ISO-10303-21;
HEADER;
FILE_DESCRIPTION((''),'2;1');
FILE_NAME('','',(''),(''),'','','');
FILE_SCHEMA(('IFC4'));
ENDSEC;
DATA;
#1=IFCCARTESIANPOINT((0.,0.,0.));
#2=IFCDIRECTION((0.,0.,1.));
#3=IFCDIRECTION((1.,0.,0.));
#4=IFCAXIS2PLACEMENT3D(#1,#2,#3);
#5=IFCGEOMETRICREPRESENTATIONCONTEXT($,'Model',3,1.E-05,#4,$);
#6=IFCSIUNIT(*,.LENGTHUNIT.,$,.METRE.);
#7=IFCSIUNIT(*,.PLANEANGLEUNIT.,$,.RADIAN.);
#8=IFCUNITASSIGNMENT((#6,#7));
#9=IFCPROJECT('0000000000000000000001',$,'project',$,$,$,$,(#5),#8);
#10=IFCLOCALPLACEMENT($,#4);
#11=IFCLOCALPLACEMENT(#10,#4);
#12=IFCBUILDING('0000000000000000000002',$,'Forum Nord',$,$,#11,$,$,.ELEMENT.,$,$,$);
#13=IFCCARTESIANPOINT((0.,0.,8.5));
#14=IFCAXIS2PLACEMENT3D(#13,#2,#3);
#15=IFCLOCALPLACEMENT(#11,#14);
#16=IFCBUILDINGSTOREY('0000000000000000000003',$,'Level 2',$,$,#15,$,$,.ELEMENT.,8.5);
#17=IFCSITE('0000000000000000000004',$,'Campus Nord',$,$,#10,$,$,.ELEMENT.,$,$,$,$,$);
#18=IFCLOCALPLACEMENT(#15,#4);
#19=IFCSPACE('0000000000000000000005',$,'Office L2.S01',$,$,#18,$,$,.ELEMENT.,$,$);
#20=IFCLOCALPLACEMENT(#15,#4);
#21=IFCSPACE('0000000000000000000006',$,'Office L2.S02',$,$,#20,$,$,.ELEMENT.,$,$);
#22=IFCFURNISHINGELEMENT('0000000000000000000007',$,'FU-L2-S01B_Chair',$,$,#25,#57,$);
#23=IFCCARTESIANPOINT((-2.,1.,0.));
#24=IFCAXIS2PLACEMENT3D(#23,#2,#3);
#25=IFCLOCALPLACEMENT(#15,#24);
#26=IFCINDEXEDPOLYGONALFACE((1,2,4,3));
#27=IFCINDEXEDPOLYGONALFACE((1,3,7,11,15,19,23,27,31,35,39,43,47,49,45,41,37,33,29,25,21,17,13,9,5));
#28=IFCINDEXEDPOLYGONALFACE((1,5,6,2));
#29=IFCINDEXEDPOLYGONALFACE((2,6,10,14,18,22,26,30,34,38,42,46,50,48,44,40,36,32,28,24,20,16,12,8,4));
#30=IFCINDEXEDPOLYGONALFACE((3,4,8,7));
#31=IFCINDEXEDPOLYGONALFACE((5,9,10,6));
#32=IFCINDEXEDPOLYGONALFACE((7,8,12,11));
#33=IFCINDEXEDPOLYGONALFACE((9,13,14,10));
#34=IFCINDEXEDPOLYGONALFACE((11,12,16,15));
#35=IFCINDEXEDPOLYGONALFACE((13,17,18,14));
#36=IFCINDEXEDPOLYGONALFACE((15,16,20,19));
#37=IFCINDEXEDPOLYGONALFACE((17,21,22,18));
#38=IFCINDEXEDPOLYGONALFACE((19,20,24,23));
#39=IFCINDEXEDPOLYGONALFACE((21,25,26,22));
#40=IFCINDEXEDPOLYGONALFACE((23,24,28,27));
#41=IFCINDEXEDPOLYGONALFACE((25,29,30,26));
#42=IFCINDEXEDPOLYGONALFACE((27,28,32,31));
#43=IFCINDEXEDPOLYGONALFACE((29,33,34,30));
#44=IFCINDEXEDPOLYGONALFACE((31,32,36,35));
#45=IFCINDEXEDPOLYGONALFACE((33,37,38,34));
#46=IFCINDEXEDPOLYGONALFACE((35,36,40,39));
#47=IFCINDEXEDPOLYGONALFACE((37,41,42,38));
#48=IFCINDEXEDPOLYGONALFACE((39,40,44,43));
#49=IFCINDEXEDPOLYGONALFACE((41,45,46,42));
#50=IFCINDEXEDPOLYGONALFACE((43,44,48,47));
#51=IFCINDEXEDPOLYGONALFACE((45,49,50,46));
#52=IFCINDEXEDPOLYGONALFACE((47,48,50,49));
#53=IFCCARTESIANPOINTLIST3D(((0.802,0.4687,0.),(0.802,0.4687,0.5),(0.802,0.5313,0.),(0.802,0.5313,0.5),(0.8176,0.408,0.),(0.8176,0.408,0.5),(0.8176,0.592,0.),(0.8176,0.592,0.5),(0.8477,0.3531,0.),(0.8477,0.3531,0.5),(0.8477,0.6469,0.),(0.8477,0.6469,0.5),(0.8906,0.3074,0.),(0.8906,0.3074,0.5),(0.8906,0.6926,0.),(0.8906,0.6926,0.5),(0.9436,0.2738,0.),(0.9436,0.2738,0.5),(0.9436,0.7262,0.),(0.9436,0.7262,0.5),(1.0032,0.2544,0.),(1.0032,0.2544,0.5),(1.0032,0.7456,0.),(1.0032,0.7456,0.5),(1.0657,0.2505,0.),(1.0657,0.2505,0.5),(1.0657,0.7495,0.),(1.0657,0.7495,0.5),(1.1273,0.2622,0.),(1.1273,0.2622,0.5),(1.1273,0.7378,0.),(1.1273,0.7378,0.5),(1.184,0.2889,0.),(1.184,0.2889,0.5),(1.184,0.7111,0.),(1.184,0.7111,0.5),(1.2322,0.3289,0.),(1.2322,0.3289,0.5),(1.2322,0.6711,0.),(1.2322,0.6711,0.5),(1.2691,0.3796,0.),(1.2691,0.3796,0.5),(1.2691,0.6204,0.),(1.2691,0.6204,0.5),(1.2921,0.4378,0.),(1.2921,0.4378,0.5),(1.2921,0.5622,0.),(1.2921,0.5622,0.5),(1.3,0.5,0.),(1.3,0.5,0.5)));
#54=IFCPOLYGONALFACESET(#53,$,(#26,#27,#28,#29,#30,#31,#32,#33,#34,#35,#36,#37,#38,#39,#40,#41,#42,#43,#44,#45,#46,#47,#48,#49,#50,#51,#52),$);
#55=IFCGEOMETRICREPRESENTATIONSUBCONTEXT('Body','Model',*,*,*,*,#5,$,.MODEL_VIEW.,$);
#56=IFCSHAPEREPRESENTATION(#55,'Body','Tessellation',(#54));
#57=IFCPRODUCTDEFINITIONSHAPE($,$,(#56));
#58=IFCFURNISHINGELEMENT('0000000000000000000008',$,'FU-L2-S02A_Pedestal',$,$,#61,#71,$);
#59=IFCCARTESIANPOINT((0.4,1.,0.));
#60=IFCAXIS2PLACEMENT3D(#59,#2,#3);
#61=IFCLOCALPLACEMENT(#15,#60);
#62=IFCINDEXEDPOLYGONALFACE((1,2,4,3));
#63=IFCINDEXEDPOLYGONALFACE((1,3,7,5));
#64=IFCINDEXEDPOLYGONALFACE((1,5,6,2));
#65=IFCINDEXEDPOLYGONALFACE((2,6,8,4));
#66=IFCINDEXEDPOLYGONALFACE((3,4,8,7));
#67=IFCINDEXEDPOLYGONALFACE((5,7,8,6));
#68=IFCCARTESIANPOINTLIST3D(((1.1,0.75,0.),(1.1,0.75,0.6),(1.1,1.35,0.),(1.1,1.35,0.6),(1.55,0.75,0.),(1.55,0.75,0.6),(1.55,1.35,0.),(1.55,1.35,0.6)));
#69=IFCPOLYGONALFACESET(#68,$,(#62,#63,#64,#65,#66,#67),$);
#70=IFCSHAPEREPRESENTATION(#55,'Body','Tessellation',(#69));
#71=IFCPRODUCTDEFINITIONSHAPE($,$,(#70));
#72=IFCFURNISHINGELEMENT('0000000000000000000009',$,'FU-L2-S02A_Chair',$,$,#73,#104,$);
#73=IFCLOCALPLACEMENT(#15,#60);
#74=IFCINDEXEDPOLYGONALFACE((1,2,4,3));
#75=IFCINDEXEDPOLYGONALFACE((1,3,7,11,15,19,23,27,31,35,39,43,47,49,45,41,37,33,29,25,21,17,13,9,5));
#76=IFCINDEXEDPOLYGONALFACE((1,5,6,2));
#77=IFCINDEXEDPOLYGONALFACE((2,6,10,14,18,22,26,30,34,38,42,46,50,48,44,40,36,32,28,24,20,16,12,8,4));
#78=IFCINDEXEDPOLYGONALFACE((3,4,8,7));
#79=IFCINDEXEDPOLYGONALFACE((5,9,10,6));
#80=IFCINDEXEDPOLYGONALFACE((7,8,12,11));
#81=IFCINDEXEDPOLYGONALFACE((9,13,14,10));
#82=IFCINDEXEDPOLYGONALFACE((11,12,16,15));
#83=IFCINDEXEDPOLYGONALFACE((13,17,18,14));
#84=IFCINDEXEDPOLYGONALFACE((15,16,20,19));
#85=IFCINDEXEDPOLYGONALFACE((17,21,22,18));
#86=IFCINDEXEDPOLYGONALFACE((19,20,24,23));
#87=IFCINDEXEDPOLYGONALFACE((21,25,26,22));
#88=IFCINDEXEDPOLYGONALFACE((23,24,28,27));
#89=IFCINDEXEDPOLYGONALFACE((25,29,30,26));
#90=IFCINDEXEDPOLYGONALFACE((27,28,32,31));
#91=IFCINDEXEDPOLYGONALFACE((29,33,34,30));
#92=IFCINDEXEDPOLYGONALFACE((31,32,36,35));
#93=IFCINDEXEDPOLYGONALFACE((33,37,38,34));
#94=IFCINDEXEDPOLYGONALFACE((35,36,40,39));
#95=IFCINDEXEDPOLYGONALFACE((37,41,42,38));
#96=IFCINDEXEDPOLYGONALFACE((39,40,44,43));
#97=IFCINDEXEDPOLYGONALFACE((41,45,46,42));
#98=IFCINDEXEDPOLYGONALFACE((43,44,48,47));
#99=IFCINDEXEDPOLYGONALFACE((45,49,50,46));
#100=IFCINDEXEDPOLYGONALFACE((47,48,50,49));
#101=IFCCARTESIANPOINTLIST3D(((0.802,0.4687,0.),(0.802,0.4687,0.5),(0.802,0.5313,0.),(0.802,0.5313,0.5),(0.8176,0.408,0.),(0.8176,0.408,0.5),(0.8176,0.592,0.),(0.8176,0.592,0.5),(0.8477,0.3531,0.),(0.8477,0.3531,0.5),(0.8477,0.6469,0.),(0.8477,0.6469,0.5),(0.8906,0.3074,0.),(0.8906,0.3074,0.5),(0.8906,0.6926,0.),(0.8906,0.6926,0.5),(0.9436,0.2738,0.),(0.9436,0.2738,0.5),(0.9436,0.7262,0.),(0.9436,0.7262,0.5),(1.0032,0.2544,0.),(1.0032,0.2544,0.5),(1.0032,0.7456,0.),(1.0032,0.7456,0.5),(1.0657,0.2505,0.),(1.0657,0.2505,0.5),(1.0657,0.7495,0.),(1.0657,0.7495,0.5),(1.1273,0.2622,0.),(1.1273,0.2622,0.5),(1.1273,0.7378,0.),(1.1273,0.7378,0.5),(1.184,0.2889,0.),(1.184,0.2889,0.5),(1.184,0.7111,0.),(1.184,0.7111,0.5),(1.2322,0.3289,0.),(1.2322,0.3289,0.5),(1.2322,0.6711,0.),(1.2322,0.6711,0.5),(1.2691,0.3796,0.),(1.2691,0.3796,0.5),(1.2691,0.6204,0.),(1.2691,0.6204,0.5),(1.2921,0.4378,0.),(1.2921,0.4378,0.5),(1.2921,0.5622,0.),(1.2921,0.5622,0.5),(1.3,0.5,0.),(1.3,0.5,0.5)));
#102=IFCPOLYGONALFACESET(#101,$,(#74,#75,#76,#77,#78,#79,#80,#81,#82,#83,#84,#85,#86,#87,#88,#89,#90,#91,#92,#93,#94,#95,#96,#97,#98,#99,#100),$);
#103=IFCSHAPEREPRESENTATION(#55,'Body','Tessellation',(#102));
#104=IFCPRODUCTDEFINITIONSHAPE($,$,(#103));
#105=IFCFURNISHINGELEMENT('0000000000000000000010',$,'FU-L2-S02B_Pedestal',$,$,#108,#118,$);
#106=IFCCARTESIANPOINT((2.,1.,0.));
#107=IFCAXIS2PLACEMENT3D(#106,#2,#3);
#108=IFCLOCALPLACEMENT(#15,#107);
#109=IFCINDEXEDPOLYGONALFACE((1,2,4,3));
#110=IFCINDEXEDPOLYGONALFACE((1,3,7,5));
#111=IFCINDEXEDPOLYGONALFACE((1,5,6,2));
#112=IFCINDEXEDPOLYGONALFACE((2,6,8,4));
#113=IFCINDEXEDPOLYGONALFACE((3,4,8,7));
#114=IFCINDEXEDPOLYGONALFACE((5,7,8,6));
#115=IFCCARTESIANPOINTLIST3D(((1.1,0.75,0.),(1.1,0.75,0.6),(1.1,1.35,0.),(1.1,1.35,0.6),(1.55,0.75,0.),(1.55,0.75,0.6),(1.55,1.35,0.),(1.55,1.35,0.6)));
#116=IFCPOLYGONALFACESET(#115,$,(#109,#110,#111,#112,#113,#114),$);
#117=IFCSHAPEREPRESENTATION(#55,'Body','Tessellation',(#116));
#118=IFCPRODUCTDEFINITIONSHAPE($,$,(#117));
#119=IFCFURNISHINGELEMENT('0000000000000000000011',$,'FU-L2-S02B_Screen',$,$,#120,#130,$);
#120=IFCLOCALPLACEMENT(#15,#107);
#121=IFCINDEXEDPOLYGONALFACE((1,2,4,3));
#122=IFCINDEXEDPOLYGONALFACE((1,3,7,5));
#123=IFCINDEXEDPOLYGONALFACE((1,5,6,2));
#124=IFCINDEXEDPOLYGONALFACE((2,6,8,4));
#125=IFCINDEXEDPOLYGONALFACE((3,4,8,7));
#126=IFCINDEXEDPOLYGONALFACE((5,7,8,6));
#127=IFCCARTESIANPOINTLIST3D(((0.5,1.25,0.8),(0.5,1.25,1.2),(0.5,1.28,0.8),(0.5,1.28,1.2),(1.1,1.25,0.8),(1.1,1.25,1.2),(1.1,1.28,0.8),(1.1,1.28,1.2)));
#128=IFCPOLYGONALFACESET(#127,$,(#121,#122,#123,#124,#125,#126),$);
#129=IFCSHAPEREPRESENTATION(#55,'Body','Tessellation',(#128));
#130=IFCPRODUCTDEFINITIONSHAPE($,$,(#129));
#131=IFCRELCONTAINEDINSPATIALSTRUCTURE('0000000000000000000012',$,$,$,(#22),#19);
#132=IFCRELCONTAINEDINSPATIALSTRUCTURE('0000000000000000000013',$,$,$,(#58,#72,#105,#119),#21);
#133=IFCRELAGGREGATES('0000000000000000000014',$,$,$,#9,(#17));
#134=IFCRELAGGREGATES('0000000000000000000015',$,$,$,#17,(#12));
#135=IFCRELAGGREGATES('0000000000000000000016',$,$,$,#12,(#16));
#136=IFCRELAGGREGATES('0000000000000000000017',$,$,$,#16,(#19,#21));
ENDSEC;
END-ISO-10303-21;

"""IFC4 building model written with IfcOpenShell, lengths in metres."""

from ifc_helpers import new_model, si_unit, frame, frame_2d, origin_with_axes, place, context, subcontext, project, spatial, rectangle, circle, extrude, element, save


model = new_model("IFC4")

# Units and contexts
model_context = context("Model", 3, precision=1e-05, world=origin_with_axes())
body_context = subcontext(model_context, "Body", "Model", "MODEL_VIEW")
ifc_project = project(units=[si_unit("LENGTHUNIT", "METRE"), si_unit("PLANEANGLEUNIT", "RADIAN")], contexts=[model_context])

# Site, building, storey
site_placement = place(None, origin_with_axes())
site = spatial("IfcSite", under=ifc_project, at=site_placement, Name="Campus Nord", CompositionType="ELEMENT")
building_placement = place(site_placement, origin_with_axes())
building = spatial("IfcBuilding", under=site, at=building_placement, Name="Forum Nord", CompositionType="ELEMENT")
storey_placement = place(building_placement, frame((0.0, 0.0, 8.5), z_axis=(0.0, 0.0, 1.0), x_axis=(1.0, 0.0, 0.0)))
storey = spatial("IfcBuildingStorey", under=building, at=storey_placement, Name="Level 2", CompositionType="ELEMENT", Elevation=8.5)

# Shared definitions
space_1_placement = place(storey_placement, origin_with_axes())
space_1 = spatial("IfcSpace", under=storey, at=space_1_placement, Name="Office L2.S01", CompositionType="ELEMENT")

# Furnishing element
furnishing_1_placement = place(storey_placement, frame((-2.0, 1.0, 0.0), z_axis=(0.0, 0.0, 1.0), x_axis=(1.0, 0.0, 0.0)))
element("IfcFurnishingElement", 1, at=furnishing_1_placement, inside=space_1, Name="FU-L2-S01B_Chair", context=body_context, shape_type="SweptSolid", body=[
    extrude(circle(Radius=0.25, at=frame_2d((1.05, 0.5), x_axis=(1.0, 0.0))), origin_with_axes(), (0.0, 0.0, 1.0), 0.5),
])

# Shared definitions
space_2_placement = place(storey_placement, origin_with_axes())
space_2 = spatial("IfcSpace", under=storey, at=space_2_placement, Name="Office L2.S02", CompositionType="ELEMENT")

# Furnishing elements
furnishing_2_placement = place(storey_placement, frame((0.4, 1.0, 0.0), z_axis=(0.0, 0.0, 1.0), x_axis=(1.0, 0.0, 0.0)))
element("IfcFurnishingElement", 2, at=furnishing_2_placement, inside=space_2, Name="FU-L2-S02A_Pedestal", context=body_context, shape_type="SweptSolid", body=[
    extrude(rectangle(XDim=0.45, YDim=0.6, at=frame_2d((1.325, 1.05), x_axis=(1.0, 0.0))), origin_with_axes(), (0.0, 0.0, 1.0), 0.6),
])
furnishing_3_placement = place(storey_placement, frame((0.4, 1.0, 0.0), z_axis=(0.0, 0.0, 1.0), x_axis=(1.0, 0.0, 0.0)))
element("IfcFurnishingElement", 3, at=furnishing_3_placement, inside=space_2, Name="FU-L2-S02A_Chair", context=body_context, shape_type="SweptSolid", body=[
    extrude(circle(Radius=0.25, at=frame_2d((1.05, 0.5), x_axis=(1.0, 0.0))), origin_with_axes(), (0.0, 0.0, 1.0), 0.5),
])
furnishing_4_placement = place(storey_placement, frame((2.0, 1.0, 0.0), z_axis=(0.0, 0.0, 1.0), x_axis=(1.0, 0.0, 0.0)))
element("IfcFurnishingElement", 4, at=furnishing_4_placement, inside=space_2, Name="FU-L2-S02B_Pedestal", context=body_context, shape_type="SweptSolid", body=[
    extrude(rectangle(XDim=0.45, YDim=0.6, at=frame_2d((1.325, 1.05), x_axis=(1.0, 0.0))), origin_with_axes(), (0.0, 0.0, 1.0), 0.6),
])
furnishing_5_placement = place(storey_placement, frame((2.0, 1.0, 0.0), z_axis=(0.0, 0.0, 1.0), x_axis=(1.0, 0.0, 0.0)))
element("IfcFurnishingElement", 5, at=furnishing_5_placement, inside=space_2, Name="FU-L2-S02B_Screen", context=body_context, shape_type="SweptSolid", body=[
    extrude(rectangle(XDim=0.6, YDim=0.03, at=frame_2d((0.8, 1.265), x_axis=(1.0, 0.0))), frame((0.0, 0.0, 0.8), z_axis=(0.0, 0.0, 1.0), x_axis=(1.0, 0.0, 0.0)), (0.0, 0.0, 1.0), 0.4),
])

save(model, "model.ifc")
